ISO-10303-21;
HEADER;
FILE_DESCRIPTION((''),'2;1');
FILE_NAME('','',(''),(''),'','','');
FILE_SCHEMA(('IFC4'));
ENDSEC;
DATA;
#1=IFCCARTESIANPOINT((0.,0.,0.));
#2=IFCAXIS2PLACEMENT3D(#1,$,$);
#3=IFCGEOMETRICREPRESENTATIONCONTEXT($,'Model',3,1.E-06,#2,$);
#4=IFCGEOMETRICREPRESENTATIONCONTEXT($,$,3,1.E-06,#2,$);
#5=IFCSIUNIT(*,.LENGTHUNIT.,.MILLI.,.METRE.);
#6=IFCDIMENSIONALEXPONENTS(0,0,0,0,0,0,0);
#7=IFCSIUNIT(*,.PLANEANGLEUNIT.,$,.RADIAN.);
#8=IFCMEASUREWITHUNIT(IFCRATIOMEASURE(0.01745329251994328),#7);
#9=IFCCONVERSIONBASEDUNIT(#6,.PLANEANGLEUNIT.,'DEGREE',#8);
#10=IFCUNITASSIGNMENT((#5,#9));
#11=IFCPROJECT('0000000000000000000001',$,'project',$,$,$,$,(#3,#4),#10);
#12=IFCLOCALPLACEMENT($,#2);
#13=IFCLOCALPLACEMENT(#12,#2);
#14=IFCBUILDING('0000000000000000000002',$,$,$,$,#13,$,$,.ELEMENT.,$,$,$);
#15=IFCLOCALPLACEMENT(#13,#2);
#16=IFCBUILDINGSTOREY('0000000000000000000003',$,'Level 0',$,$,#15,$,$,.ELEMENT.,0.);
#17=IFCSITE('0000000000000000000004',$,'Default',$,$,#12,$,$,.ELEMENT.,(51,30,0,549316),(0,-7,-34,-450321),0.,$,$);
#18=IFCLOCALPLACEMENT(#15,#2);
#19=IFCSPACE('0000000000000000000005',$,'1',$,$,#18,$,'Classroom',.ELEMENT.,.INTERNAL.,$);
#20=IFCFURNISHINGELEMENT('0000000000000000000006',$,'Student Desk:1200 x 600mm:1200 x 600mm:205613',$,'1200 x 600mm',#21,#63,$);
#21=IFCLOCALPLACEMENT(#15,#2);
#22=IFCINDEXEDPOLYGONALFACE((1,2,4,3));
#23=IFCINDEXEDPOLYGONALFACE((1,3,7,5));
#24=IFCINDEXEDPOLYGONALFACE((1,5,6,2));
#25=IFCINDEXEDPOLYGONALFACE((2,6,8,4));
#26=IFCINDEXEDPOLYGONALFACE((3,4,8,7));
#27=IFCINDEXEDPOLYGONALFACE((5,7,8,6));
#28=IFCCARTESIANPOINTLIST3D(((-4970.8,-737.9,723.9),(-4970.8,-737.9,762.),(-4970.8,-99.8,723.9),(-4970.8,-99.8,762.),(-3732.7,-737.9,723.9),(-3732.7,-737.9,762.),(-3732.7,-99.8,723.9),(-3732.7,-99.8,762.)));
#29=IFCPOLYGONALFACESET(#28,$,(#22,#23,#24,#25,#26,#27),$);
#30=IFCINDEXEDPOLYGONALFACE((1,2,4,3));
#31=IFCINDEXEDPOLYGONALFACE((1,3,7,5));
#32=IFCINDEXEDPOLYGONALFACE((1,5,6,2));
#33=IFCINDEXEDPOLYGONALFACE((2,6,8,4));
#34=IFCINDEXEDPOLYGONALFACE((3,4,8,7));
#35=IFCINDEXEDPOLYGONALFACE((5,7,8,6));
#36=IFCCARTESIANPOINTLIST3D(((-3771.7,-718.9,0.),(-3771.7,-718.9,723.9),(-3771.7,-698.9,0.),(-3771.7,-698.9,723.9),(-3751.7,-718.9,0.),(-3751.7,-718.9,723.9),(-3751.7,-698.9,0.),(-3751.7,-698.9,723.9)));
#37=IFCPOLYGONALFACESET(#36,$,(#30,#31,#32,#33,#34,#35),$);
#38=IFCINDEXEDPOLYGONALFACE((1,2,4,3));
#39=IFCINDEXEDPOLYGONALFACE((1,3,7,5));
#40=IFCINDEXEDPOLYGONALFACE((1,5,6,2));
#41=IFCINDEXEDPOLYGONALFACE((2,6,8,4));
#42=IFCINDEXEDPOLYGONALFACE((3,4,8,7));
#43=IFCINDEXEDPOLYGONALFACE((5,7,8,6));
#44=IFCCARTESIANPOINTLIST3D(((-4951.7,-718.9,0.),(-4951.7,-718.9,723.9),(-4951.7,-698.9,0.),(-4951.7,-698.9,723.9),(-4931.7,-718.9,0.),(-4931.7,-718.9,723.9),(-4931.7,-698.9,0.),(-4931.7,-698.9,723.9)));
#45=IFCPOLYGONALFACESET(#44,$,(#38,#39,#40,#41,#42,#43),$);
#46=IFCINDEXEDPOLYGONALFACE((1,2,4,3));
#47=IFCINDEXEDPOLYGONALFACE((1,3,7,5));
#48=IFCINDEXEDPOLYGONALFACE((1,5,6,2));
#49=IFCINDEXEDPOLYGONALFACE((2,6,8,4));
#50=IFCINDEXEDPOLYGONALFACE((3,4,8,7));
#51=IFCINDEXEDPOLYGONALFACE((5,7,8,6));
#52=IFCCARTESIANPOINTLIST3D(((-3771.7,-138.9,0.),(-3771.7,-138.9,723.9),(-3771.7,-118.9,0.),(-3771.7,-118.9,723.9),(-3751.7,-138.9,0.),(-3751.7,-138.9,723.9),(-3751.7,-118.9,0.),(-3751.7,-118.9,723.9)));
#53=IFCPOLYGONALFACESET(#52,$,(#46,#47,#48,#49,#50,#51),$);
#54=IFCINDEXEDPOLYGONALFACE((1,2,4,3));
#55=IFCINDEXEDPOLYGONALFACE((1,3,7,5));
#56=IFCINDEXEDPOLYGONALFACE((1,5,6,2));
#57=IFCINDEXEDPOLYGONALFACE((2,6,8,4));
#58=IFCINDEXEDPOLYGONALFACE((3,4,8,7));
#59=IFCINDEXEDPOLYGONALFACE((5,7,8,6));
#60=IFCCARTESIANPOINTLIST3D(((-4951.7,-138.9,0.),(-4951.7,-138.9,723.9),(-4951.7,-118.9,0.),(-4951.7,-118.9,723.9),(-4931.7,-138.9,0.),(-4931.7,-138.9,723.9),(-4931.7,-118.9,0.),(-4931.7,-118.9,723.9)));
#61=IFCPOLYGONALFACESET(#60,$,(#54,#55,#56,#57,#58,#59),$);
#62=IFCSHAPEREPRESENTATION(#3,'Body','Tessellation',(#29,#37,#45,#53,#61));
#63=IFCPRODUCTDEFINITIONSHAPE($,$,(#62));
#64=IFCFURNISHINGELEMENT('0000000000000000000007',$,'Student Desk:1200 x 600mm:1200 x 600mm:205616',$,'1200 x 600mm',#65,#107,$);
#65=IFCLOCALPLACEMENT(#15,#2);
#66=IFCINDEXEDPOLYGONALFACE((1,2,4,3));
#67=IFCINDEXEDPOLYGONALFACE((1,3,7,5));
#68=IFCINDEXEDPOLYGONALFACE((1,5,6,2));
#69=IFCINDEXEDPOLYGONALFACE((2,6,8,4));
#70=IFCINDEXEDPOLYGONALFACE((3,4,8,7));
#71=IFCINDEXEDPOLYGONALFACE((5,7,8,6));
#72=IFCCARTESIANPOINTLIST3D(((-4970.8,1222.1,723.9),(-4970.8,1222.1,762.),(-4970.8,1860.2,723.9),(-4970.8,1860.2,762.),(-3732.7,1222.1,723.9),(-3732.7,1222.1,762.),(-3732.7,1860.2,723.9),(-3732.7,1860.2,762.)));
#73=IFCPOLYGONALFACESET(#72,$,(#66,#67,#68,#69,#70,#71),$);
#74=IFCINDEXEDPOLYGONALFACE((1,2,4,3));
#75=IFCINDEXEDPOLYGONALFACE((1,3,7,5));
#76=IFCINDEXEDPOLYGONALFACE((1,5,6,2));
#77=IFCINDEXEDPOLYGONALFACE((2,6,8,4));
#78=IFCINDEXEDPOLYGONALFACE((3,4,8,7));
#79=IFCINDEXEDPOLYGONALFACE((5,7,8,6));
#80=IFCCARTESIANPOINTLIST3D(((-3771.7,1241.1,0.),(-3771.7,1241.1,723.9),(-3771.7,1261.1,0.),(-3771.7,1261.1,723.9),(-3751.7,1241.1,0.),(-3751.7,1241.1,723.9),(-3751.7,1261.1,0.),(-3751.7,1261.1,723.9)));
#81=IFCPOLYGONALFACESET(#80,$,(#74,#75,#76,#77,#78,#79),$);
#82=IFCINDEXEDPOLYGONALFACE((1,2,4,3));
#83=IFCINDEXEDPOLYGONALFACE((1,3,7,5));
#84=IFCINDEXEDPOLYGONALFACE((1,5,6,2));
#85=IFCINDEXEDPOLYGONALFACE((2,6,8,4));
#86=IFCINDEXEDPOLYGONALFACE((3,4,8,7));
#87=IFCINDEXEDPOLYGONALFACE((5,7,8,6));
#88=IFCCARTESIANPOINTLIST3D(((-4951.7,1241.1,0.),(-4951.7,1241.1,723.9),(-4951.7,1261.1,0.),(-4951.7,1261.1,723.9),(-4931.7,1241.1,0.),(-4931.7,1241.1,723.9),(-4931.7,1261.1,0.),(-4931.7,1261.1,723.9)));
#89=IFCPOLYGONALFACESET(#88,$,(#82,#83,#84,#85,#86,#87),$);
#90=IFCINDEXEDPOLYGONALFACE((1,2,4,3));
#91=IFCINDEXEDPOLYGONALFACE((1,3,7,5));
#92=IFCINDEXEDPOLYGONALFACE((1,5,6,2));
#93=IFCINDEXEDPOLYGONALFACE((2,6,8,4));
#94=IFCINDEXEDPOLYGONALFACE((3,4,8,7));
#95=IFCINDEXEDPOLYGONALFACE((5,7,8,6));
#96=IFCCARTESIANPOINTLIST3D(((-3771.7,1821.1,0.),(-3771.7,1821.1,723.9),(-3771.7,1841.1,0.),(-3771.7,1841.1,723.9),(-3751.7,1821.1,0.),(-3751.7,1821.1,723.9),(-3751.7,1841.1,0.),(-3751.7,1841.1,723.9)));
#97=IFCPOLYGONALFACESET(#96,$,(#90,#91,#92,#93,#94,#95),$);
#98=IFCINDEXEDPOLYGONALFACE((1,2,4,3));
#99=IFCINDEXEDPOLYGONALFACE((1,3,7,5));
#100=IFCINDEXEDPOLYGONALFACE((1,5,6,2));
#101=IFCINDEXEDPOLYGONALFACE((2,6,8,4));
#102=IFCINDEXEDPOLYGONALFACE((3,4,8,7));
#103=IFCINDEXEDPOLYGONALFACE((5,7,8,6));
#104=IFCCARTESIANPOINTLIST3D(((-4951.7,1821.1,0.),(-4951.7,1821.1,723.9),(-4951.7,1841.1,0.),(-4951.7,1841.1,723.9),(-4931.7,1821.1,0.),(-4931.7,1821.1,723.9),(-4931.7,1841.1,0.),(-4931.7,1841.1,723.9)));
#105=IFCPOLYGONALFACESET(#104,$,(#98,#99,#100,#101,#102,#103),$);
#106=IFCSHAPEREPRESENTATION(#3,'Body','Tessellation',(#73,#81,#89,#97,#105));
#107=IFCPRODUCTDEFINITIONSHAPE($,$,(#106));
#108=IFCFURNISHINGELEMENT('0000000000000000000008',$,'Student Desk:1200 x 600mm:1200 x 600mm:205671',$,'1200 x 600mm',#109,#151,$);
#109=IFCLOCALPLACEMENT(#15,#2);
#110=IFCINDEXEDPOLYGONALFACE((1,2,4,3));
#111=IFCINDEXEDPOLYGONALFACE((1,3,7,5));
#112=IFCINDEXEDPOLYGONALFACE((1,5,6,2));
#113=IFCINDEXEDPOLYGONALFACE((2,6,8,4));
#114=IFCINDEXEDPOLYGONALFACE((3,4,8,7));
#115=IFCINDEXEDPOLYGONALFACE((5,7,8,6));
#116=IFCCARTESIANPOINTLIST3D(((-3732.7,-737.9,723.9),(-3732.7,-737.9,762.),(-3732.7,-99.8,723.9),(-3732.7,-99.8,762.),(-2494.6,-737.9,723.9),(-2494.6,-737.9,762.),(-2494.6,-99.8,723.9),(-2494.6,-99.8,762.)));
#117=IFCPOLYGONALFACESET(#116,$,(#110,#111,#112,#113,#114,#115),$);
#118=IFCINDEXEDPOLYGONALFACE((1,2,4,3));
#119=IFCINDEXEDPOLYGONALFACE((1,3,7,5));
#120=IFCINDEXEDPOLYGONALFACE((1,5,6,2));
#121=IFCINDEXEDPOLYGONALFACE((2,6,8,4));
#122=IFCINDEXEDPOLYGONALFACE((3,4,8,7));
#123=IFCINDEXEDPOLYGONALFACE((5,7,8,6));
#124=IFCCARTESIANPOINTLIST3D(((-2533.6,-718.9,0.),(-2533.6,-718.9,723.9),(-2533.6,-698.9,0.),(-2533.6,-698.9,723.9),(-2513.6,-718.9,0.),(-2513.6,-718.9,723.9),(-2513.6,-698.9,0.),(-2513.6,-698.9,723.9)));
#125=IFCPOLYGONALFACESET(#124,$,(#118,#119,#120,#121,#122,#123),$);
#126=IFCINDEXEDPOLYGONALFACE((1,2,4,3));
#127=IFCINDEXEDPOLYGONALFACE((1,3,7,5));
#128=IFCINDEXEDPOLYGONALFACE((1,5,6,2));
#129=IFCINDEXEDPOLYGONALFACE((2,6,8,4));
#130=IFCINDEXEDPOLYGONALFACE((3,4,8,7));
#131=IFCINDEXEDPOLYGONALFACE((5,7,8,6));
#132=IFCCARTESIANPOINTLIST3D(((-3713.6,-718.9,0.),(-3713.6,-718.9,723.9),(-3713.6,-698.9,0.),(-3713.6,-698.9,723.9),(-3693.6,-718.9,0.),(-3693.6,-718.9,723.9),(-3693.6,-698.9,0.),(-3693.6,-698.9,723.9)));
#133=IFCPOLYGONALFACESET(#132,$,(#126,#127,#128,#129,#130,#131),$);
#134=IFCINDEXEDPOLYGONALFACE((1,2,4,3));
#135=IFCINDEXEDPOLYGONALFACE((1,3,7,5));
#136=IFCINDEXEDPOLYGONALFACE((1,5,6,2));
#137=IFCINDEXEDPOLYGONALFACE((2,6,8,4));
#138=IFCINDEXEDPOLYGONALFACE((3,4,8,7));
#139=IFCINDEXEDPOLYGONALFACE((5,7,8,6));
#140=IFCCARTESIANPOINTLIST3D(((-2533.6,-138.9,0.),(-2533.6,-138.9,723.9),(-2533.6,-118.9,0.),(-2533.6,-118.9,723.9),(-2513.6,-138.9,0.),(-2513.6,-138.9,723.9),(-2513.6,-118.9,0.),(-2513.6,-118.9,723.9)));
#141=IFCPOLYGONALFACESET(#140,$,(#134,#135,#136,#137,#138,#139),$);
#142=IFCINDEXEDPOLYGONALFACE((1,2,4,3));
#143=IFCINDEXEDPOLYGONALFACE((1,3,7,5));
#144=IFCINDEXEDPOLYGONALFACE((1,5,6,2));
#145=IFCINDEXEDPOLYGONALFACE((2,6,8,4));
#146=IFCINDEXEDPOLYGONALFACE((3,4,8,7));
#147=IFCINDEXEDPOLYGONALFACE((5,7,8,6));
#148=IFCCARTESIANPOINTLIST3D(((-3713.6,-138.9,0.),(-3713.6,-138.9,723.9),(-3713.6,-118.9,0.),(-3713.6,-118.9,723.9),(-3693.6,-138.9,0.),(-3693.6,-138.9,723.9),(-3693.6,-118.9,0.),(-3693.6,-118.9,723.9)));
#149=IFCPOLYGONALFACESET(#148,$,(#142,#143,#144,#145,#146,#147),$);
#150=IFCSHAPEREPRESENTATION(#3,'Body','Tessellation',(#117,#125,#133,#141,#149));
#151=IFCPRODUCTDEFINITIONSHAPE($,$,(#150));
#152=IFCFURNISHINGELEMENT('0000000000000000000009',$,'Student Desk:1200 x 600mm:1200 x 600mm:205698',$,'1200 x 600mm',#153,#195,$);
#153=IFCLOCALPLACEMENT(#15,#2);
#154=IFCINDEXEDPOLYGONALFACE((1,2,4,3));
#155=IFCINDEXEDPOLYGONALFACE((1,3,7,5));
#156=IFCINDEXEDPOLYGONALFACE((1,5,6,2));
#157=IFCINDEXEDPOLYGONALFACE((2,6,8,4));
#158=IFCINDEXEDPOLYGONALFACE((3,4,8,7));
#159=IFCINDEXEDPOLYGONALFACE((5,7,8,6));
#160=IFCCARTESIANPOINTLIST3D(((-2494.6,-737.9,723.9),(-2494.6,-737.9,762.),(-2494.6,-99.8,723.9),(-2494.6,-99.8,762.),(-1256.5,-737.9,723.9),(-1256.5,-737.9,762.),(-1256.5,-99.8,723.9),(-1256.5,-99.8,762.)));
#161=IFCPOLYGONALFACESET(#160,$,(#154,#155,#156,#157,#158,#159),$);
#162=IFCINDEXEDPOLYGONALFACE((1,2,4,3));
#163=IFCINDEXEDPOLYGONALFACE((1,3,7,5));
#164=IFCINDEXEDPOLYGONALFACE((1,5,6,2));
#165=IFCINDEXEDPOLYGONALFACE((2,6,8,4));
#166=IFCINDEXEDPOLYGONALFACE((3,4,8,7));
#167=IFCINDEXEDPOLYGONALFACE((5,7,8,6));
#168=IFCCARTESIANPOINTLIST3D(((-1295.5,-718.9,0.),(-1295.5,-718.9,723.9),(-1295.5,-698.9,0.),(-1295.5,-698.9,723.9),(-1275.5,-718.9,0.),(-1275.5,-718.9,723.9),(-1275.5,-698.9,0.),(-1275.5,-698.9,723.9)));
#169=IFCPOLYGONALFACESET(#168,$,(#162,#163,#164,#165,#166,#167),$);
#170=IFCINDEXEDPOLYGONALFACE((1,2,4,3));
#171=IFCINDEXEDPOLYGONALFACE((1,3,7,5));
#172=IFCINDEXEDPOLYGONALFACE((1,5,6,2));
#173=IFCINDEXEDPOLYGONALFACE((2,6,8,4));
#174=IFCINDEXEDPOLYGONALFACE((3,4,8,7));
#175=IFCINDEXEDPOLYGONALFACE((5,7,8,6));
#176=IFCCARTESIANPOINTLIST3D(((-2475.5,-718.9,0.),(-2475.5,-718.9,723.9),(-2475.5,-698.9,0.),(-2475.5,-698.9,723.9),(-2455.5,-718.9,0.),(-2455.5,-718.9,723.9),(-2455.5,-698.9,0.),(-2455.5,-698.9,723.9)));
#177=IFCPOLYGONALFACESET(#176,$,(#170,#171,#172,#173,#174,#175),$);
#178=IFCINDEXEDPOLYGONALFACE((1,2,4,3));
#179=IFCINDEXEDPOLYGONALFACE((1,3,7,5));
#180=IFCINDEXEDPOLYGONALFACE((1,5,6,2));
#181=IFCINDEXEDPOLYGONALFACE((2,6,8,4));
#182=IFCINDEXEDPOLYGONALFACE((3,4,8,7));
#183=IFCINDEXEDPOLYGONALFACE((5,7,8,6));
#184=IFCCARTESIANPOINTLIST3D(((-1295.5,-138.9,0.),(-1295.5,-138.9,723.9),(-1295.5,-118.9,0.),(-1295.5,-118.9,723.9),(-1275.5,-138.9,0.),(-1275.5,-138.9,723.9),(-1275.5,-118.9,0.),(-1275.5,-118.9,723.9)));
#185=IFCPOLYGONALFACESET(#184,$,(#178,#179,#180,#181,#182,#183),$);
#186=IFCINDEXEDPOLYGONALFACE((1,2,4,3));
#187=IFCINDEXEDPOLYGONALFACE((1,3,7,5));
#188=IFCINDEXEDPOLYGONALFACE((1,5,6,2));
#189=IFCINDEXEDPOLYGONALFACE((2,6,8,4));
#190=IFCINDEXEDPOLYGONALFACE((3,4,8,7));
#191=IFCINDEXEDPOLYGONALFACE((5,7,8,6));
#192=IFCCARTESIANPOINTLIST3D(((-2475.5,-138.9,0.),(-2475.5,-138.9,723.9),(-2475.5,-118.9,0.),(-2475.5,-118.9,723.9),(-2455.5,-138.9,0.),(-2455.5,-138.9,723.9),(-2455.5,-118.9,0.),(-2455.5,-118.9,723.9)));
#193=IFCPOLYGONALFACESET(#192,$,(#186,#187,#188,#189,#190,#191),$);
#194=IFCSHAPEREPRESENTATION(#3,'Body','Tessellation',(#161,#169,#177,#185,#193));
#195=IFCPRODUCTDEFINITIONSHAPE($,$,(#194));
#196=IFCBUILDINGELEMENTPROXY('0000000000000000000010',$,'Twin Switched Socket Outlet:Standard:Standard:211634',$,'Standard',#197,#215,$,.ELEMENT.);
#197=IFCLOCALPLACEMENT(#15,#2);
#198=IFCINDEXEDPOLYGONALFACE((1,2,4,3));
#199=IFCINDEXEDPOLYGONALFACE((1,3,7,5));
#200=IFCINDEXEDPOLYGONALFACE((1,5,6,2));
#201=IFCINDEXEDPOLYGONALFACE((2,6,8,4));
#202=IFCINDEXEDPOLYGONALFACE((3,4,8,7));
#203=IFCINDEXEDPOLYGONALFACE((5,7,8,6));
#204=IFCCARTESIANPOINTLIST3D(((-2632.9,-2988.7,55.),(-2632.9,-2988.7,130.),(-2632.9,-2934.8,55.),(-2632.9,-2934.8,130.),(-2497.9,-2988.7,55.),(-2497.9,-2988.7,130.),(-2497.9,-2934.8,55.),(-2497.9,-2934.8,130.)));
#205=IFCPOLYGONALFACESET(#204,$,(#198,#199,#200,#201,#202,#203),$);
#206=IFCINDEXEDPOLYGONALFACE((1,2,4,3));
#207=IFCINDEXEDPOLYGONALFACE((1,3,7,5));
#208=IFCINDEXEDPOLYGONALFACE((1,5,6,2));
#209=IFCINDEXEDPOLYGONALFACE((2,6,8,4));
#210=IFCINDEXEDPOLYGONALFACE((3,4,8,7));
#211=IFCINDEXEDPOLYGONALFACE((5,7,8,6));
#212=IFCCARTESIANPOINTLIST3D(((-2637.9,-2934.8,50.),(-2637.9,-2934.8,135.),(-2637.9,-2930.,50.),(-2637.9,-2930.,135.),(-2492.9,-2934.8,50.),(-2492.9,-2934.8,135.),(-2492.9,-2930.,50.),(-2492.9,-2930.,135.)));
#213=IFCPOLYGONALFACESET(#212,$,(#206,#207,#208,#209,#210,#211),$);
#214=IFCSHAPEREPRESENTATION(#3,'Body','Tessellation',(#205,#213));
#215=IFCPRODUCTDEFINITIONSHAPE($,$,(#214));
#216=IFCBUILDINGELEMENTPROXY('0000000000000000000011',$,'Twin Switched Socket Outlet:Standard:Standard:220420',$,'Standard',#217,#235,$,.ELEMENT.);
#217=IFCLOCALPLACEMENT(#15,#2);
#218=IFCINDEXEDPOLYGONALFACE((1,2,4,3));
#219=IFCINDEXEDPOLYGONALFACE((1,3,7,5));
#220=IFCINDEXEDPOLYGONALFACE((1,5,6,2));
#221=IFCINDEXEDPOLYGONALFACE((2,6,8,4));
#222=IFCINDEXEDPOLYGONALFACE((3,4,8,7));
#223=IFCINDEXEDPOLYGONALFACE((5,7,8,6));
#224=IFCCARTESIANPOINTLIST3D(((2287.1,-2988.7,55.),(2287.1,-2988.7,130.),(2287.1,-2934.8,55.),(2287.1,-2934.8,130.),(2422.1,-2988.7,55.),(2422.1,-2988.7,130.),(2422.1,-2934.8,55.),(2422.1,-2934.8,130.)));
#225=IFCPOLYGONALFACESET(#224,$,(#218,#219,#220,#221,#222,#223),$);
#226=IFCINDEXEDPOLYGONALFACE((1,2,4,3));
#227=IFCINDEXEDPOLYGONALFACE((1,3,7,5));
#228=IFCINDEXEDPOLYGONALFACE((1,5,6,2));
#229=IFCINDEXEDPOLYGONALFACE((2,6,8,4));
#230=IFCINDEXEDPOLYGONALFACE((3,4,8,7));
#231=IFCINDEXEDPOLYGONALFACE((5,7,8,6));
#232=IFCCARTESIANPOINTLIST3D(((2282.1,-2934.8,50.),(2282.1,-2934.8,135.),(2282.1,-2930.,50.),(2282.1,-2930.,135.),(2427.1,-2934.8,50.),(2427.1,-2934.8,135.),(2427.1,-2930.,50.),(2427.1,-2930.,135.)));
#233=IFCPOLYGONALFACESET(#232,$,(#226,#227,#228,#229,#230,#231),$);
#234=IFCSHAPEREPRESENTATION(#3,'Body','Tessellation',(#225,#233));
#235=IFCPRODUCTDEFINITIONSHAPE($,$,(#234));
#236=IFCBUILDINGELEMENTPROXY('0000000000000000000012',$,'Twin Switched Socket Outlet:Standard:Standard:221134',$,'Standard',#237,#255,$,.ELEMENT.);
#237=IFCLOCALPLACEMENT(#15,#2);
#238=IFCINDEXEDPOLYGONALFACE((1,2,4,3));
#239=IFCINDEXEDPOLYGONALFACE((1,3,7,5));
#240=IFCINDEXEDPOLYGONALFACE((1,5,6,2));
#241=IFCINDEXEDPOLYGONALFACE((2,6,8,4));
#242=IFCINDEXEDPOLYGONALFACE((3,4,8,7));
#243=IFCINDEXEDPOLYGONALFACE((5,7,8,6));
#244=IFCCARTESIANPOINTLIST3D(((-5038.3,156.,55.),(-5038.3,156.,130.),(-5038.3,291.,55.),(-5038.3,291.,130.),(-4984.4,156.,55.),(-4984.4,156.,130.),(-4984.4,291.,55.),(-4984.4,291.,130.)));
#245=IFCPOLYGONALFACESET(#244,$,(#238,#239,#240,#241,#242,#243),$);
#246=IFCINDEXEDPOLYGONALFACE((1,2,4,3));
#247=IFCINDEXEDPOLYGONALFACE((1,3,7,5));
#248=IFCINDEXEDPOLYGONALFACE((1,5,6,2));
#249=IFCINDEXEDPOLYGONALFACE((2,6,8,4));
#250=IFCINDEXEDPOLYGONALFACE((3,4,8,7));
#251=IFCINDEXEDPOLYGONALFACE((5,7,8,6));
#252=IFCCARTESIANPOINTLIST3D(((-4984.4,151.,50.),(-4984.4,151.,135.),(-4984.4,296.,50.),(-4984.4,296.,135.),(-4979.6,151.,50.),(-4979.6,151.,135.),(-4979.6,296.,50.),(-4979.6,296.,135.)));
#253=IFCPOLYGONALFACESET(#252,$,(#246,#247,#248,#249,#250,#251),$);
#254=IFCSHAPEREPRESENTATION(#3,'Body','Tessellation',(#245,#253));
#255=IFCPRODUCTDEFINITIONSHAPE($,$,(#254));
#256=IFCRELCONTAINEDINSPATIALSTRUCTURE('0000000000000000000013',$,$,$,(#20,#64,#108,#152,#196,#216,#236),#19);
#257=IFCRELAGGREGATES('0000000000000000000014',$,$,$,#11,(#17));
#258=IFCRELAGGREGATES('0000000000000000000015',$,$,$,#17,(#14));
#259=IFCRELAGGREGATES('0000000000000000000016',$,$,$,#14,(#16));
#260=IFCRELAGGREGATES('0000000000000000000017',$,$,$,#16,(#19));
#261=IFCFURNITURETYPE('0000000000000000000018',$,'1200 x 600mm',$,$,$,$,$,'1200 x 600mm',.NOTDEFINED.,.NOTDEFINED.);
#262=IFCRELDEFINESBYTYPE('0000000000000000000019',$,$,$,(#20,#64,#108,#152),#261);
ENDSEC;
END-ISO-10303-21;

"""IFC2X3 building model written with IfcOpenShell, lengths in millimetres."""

from ifc_helpers import new_model, entity, si_unit, converted_unit, frame, origin, origin_2d_with_axis, place, context, project, spatial, rectangle, extrude, source, transform, mapped, type_object, type_shapes, element, save


model = new_model("IFC2X3")

# Units and contexts
model_context = context("Model", 3, precision=1e-06, world=origin())
context_of_model = context(None, 3, precision=1e-06, world=origin())
ifc_project = project(units=[si_unit("LENGTHUNIT", "METRE", prefix="MILLI"), converted_unit("PLANEANGLEUNIT", "DEGREE", entity("IfcRatioMeasure", 0.01745329251994328), si_unit("PLANEANGLEUNIT", "RADIAN"), dimensions=[0, 0, 0, 0, 0, 0, 0])], contexts=[model_context, context_of_model])

# Site, building, storey
site_placement = place(None, origin())
site = spatial("IfcSite", under=ifc_project, at=site_placement, Name="Default", CompositionType="ELEMENT", RefLatitude=(51, 30, 0, 549316), RefLongitude=(0, -7, -34, -450321), RefElevation=0.0)
building_placement = place(site_placement, origin())
building = spatial("IfcBuilding", under=site, at=building_placement, CompositionType="ELEMENT")
storey_placement = place(building_placement, origin())
storey = spatial("IfcBuildingStorey", under=building, at=storey_placement, Name="Level 0", CompositionType="ELEMENT", Elevation=0.0)

# Shared definitions
space_placement = place(storey_placement, origin())
space = spatial("IfcSpace", under=storey, at=space_placement, Name="1", LongName="Classroom", CompositionType="ELEMENT", InteriorOrExteriorSpace="INTERNAL")

# Furnishing elements
furniture_type = type_object("IfcFurnitureType", Name="1200 x 600mm", ElementType="1200 x 600mm", AssemblyPlace="NOTDEFINED")
shared_shape_1 = source(origin(), model_context, "Body", "SweptSolid", [
    extrude(rectangle(XDim=1238.1, YDim=638.1, at=origin_2d_with_axis()), frame((600.0, 300.0, 723.9), z_axis=(0.0, 0.0, 1.0), x_axis=(-1.0, 0.0, 0.0)), (0.0, 0.0, 1.0), 38.1),
    extrude(rectangle(XDim=20.0, YDim=20.0, at=origin_2d_with_axis()), frame((1190.0, 10.0, 0.0)), (0.0, 0.0, 1.0), 723.9),
    extrude(rectangle(XDim=20.0, YDim=20.0, at=origin_2d_with_axis()), frame((10.0, 10.0, 0.0), z_axis=(0.0, 0.0, 1.0), x_axis=(0.0, 1.0, 0.0)), (0.0, 0.0, 1.0), 723.9),
    extrude(rectangle(XDim=20.0, YDim=20.0, at=origin_2d_with_axis()), frame((1190.0, 590.0, 0.0), z_axis=(0.0, 0.0, 1.0), x_axis=(0.0, -1.0, 0.0)), (0.0, 0.0, 1.0), 723.9),
    extrude(rectangle(XDim=20.0, YDim=20.0, at=origin_2d_with_axis()), frame((10.0, 590.0, 0.0), z_axis=(0.0, 0.0, 1.0), x_axis=(-1.0, 0.0, 0.0)), (0.0, 0.0, 1.0), 723.9),
])
type_shapes(furniture_type, [shared_shape_1])
for number, where, name in (
    (1, (-4951.7, -718.9, 0.0), "Student Desk:1200 x 600mm:1200 x 600mm:205613"),
    (2, (-4951.7, 1241.1, 0.0), "Student Desk:1200 x 600mm:1200 x 600mm:205616"),
    (3, (-3713.6, -718.9, 0.0), "Student Desk:1200 x 600mm:1200 x 600mm:205671"),
    (4, (-2475.5, -718.9, 0.0), "Student Desk:1200 x 600mm:1200 x 600mm:205698"),
):
    element("IfcFurnishingElement", number, at=place(space_placement, frame(where)), inside=space, type_object=furniture_type, Name=name, ObjectType="1200 x 600mm", context=model_context, shape_type="MappedRepresentation", body=[
        mapped(shared_shape_1, transform((0.0, 0.0, 0.0), scale=1.0)),
    ])

# Building element proxies
shared_shape_2 = source(origin(), model_context, "Body", "SweptSolid", [
    extrude(rectangle(XDim=135.0, YDim=75.0, at=origin_2d_with_axis()), frame((0.0, 0.0, -54.0), z_axis=(0.0, 0.0, 1.0), x_axis=(-1.0, 0.0, 0.0)), (0.0, 0.0, 1.0), 54.0),
    extrude(rectangle(XDim=145.0, YDim=85.0, at=origin_2d_with_axis()), frame((0.0, 0.0, 0.0), z_axis=(0.0, 0.0, 1.0), x_axis=(-1.0, 0.0, 0.0)), (0.0, 0.0, 1.0), 4.8),
])
for number, where, z_axis, x_axis, name in (
    (5, (-2565.4, -2934.8, 92.5), (0.0, 1.0, 0.0), (-1.0, 0.0, 0.0), "Twin Switched Socket Outlet:Standard:Standard:211634"),
    (6, (2354.6, -2934.8, 92.5), (0.0, 1.0, 0.0), (-1.0, 0.0, 0.0), "Twin Switched Socket Outlet:Standard:Standard:220420"),
    (7, (-4984.4, 223.5, 92.5), (1.0, 0.0, 0.0), (0.0, 1.0, 0.0), "Twin Switched Socket Outlet:Standard:Standard:221134"),
):
    element("IfcBuildingElementProxy", number, at=place(space_placement, frame(where, z_axis=z_axis, x_axis=x_axis)), inside=space, Name=name, ObjectType="Standard", CompositionType="ELEMENT", context=model_context, shape_type="MappedRepresentation", body=[
        mapped(shared_shape_2, transform((0.0, 0.0, 0.0), scale=1.0)),
    ])

save(model, "model.ifc")
